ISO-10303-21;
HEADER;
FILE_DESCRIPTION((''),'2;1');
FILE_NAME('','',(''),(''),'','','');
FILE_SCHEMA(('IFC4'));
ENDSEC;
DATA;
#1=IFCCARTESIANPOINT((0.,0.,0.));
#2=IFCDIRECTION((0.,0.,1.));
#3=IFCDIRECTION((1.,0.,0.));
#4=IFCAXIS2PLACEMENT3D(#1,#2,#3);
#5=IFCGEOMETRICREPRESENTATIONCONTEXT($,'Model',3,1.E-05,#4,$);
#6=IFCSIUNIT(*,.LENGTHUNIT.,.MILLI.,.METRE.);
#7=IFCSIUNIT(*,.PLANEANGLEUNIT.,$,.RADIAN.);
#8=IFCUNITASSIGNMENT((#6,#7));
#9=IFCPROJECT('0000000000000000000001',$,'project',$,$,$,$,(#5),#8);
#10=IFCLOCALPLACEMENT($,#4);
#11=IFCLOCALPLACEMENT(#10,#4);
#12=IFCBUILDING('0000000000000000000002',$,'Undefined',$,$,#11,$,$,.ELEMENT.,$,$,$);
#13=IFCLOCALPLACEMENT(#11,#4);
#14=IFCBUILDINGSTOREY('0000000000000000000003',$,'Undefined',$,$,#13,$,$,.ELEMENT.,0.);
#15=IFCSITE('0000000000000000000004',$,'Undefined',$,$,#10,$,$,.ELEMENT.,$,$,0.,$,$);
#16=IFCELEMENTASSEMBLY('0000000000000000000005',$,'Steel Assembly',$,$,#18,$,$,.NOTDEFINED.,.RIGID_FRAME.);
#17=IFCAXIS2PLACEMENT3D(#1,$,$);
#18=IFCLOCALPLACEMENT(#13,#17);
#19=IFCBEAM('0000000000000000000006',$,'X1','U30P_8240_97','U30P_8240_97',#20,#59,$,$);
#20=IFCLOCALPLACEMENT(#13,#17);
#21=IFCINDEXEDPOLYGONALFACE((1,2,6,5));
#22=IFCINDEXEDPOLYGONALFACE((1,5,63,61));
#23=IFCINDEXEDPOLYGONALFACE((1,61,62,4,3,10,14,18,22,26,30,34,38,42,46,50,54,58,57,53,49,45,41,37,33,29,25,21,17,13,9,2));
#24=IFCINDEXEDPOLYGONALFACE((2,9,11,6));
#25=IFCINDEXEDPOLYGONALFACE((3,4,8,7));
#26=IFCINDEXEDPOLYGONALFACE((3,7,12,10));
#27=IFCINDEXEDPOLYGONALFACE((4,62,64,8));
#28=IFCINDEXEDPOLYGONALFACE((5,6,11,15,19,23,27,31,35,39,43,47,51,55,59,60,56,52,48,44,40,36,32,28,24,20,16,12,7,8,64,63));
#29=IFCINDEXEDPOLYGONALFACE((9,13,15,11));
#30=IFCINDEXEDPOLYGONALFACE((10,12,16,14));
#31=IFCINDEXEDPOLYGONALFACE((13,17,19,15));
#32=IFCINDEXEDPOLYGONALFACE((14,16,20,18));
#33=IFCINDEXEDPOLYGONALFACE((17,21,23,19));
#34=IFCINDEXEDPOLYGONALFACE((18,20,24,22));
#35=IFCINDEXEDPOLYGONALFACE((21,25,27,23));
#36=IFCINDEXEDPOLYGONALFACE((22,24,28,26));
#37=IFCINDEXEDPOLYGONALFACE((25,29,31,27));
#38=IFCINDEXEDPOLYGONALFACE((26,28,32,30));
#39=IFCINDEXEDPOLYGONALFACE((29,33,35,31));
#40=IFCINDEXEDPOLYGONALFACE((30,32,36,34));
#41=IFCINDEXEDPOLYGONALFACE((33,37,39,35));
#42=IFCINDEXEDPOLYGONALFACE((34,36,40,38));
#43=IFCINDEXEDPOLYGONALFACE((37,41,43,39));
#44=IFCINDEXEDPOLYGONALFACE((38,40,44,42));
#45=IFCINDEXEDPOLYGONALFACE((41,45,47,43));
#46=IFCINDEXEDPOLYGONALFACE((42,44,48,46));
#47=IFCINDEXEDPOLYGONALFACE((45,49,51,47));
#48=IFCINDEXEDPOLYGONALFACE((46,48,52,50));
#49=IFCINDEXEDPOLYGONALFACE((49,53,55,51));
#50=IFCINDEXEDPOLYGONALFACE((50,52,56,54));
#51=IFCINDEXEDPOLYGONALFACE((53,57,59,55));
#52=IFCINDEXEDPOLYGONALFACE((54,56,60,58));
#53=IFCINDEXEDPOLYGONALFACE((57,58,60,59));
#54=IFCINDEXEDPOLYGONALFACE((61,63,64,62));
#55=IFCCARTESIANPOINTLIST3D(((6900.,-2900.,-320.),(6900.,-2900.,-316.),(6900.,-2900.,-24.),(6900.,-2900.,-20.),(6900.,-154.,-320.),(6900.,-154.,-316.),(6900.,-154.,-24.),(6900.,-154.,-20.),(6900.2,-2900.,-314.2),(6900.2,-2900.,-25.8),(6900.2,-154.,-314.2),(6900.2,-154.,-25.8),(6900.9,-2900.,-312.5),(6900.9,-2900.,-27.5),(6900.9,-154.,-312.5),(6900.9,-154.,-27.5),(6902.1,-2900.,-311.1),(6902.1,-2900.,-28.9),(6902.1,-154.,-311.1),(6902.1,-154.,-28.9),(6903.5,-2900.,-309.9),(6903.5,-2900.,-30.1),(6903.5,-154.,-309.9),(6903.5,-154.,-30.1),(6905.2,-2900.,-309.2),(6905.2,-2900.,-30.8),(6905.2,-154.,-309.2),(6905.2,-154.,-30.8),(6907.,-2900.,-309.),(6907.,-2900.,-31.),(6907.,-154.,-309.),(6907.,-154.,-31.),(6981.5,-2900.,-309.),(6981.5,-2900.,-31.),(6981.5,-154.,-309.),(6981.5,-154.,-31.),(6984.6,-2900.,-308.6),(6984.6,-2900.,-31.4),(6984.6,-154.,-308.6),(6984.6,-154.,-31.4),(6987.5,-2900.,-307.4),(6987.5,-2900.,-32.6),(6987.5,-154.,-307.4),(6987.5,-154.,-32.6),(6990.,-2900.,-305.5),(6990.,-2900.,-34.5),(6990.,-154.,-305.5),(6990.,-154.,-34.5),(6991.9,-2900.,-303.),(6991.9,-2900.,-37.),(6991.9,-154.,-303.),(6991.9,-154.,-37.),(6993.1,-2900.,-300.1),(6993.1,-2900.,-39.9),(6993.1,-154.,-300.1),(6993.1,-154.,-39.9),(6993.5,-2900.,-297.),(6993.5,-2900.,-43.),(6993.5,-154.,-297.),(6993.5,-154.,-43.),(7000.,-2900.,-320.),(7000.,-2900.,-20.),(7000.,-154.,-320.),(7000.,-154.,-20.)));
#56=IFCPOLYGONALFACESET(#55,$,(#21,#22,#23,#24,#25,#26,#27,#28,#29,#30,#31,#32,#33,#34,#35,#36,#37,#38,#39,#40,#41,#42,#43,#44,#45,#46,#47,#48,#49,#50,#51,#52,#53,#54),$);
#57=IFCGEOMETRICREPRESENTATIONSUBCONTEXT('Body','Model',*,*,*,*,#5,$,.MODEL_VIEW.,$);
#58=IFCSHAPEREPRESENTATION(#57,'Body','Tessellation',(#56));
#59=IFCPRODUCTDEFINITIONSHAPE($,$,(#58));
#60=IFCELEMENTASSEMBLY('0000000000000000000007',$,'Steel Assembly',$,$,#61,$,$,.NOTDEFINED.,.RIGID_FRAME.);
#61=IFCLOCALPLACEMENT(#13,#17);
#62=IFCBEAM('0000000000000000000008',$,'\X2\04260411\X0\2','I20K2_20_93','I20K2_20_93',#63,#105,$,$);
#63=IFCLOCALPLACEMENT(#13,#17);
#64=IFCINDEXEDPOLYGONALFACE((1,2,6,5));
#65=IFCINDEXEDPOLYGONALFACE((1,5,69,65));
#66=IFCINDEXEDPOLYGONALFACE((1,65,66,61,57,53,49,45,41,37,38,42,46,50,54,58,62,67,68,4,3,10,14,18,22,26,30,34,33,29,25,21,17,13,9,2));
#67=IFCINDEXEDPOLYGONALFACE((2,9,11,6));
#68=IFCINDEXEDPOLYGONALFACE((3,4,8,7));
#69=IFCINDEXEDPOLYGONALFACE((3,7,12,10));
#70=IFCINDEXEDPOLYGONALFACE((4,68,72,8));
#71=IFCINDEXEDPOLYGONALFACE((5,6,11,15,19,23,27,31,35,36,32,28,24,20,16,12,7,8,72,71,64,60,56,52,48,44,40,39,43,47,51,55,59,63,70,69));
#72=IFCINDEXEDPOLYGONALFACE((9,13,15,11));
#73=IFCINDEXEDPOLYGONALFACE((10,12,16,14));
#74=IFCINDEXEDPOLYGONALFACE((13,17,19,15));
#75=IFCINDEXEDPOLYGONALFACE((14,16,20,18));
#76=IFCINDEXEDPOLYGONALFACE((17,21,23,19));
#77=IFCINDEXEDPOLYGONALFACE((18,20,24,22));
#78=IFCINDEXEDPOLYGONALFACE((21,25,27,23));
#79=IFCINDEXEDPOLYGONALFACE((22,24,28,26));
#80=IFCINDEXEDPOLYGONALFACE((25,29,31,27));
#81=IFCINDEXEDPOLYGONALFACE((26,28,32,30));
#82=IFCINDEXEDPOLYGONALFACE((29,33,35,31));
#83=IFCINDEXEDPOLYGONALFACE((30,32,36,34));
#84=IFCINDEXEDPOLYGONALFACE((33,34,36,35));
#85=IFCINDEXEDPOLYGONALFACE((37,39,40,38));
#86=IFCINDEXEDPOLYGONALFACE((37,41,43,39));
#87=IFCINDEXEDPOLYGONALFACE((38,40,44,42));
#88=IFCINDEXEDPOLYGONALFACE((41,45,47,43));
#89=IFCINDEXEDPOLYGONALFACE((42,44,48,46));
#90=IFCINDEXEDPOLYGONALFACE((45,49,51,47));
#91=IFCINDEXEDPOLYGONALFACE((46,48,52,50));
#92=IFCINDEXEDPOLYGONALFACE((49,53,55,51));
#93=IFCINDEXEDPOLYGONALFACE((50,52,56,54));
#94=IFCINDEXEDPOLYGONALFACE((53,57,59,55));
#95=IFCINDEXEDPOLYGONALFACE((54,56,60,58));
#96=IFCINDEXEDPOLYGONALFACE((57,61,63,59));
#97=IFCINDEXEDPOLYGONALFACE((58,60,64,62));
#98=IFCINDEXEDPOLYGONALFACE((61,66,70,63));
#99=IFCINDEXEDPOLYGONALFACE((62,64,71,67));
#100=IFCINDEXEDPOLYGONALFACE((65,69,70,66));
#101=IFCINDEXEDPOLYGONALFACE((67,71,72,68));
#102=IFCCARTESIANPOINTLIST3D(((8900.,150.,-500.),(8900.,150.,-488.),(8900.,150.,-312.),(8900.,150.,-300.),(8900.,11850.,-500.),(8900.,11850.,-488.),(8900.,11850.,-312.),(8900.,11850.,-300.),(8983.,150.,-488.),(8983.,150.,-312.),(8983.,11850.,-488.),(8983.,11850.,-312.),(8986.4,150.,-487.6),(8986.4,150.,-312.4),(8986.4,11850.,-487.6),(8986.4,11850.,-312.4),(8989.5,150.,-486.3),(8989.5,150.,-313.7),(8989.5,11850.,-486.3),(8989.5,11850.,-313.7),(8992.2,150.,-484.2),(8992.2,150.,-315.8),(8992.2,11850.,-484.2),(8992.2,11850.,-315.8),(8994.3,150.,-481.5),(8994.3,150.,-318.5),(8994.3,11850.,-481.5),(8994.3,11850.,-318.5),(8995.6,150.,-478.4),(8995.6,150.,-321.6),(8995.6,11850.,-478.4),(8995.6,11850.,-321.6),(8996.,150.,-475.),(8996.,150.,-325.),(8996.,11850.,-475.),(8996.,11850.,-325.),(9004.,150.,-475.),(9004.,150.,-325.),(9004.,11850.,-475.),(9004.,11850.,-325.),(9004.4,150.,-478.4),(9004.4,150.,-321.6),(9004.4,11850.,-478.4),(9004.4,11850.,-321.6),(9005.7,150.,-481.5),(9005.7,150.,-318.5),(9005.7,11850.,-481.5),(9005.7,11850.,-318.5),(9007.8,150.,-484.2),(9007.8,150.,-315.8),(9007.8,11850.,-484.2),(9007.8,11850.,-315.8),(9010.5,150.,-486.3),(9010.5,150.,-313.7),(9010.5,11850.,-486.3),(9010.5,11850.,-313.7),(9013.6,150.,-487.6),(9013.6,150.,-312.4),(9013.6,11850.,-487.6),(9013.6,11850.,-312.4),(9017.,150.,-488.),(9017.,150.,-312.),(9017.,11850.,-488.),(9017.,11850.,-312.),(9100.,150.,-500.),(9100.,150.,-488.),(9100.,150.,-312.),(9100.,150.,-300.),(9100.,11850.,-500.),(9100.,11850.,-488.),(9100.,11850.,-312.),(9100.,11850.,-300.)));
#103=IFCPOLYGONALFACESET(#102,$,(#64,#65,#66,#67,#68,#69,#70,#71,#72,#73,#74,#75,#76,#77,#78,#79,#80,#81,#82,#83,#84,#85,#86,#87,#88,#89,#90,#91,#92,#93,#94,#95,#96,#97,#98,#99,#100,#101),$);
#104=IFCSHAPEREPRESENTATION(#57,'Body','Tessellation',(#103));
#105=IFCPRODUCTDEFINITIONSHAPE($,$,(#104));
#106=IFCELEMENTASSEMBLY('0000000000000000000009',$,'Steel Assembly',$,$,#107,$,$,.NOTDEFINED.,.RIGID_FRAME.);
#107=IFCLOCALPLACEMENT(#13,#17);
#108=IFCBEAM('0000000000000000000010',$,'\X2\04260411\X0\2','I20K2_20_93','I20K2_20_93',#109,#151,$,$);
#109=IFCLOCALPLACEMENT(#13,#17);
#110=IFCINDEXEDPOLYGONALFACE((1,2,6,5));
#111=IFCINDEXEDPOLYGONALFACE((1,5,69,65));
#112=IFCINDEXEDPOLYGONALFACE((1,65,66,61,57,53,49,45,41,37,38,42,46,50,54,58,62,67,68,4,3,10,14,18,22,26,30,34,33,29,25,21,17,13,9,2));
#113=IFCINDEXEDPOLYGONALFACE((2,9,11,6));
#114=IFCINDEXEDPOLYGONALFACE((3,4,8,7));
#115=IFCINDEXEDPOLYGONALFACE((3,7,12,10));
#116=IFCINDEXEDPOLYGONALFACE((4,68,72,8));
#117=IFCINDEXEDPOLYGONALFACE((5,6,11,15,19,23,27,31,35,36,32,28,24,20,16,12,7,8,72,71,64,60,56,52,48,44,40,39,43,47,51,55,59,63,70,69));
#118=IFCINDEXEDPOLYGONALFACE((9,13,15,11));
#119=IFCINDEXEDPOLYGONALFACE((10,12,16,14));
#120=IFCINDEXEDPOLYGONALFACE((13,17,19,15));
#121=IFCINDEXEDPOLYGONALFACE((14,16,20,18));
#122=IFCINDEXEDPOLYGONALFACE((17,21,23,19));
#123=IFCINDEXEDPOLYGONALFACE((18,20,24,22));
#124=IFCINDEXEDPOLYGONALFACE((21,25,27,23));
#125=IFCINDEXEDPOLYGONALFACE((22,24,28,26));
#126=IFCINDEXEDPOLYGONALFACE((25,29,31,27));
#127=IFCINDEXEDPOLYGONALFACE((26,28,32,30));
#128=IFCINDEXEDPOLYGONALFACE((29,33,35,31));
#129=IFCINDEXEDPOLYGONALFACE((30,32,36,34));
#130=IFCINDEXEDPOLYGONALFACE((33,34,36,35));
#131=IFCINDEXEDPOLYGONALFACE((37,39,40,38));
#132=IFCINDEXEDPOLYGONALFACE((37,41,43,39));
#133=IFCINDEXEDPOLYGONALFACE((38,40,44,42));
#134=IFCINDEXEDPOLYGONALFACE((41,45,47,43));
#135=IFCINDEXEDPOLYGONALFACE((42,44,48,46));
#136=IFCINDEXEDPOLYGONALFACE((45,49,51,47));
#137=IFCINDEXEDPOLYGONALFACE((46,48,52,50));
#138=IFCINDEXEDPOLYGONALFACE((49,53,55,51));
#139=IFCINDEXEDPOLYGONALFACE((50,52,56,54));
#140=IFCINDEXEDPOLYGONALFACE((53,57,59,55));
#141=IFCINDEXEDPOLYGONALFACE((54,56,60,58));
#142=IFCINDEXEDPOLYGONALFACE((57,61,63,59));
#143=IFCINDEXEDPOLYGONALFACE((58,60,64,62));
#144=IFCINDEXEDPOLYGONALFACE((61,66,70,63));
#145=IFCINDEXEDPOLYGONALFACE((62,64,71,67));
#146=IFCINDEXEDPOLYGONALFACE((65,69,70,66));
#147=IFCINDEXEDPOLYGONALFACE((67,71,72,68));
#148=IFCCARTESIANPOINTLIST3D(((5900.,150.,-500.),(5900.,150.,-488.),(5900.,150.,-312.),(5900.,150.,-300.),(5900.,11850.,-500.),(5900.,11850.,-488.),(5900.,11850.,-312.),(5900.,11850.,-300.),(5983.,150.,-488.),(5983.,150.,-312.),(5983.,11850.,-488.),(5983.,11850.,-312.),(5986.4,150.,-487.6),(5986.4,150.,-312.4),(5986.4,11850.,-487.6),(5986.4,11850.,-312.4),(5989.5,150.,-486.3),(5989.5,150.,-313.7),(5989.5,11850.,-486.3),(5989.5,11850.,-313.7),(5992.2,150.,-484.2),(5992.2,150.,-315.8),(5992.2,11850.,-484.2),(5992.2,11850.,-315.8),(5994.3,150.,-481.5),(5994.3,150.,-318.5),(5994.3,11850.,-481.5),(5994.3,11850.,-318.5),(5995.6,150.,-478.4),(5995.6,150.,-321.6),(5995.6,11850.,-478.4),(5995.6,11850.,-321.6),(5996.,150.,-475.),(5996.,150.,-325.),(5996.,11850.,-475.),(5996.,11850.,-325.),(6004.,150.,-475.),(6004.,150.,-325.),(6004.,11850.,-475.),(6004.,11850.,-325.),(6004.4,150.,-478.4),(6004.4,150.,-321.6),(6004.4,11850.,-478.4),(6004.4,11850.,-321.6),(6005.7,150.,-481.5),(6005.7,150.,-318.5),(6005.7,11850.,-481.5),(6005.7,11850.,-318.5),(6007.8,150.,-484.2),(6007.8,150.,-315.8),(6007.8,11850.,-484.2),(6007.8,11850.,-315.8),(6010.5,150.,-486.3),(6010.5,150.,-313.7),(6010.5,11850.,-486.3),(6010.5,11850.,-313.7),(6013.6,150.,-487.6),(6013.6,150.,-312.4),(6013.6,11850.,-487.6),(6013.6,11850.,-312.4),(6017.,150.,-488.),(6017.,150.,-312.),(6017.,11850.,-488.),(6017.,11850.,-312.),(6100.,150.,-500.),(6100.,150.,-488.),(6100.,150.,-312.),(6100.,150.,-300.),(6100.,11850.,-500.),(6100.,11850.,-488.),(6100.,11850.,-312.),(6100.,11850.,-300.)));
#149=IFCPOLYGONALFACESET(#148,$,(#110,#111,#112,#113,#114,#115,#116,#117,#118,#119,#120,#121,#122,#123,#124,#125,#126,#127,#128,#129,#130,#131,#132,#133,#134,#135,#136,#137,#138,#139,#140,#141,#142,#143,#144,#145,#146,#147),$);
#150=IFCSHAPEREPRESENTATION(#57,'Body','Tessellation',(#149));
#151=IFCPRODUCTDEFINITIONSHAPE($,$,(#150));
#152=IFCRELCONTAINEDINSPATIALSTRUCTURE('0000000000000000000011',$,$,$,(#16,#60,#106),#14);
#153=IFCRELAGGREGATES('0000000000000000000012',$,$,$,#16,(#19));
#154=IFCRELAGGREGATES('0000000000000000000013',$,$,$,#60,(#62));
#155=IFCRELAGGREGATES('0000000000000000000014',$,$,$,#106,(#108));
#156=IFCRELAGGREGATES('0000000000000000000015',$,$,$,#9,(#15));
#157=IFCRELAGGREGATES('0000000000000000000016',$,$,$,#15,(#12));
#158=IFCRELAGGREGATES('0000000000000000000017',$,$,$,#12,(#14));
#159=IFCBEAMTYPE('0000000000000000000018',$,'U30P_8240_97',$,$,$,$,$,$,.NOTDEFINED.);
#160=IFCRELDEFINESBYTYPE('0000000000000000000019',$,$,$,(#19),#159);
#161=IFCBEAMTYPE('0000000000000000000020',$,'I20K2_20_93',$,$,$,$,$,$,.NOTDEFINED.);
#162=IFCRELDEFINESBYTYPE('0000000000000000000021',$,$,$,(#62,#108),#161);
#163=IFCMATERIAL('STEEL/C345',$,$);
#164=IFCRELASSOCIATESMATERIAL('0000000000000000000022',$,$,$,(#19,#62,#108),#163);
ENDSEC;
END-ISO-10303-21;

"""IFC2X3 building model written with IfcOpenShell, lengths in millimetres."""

from ifc_helpers import new_model, si_unit, frame, origin_with_axes, origin_2d_with_axis, place, context, subcontext, project, spatial, i_section, u_section, extrude, material, type_object, element, aggregate, save


model = new_model("IFC2X3")

# Units and contexts
model_context = context("Model", 3, precision=1e-05, world=origin_with_axes())
body_context = subcontext(model_context, "Body", "Model", "MODEL_VIEW")
ifc_project = project(units=[si_unit("LENGTHUNIT", "METRE", prefix="MILLI"), si_unit("PLANEANGLEUNIT", "RADIAN")], contexts=[model_context])

# Site, building, storey
site_placement = place(None, origin_with_axes())
site = spatial("IfcSite", under=ifc_project, at=site_placement, Name="Undefined", CompositionType="ELEMENT", RefElevation=0.0)
building_placement = place(site_placement, origin_with_axes())
building = spatial("IfcBuilding", under=site, at=building_placement, Name="Undefined", CompositionType="ELEMENT")
storey_placement = place(building_placement, origin_with_axes())
storey = spatial("IfcBuildingStorey", under=building, at=storey_placement, Name="Undefined", CompositionType="ELEMENT", Elevation=0.0)

# Shared definitions
ifc_material_1 = material(Name="STEEL/C345")

# Element assemblies, beams
beam_type_1 = type_object("IfcBeamType", Name="U30P_8240_97", PredefinedType="NOTDEFINED")
assembly_1_placement = place(storey_placement, origin_with_axes())
assembly_1 = element("IfcElementAssembly", 1, at=assembly_1_placement, inside=storey, Name="Steel Assembly", AssemblyPlace="NOTDEFINED", PredefinedType="RIGID_FRAME")
beam_1_placement = place(assembly_1_placement, frame((6950.0, -154.0, -170.0), z_axis=(0.0, 0.0, 1.0), x_axis=(0.0, -1.0, 0.0)))
beam_1 = element("IfcBeam", 2, at=beam_1_placement, type_object=beam_type_1, material=ifc_material_1, Name="X1", Description="U30P_8240_97", ObjectType="U30P_8240_97", context=body_context, shape_type="SweptSolid", body=[
    extrude(u_section(Depth=300.0, FlangeWidth=100.0, WebThickness=6.5, FlangeThickness=11.0, FilletRadius=12.0, EdgeRadius=7.0, at=origin_2d_with_axis()), frame((2746.0, 0.0, 0.0), z_axis=(-1.0, 0.0, 0.0), x_axis=(0.0, -1.0, 0.0)), (0.0, 0.0, 1.0), 2746.0),
])
aggregate(assembly_1, [beam_1])
assembly_2_placement = place(storey_placement, origin_with_axes())
assembly_2 = element("IfcElementAssembly", 3, at=assembly_2_placement, inside=storey, Name="Steel Assembly", AssemblyPlace="NOTDEFINED", PredefinedType="RIGID_FRAME")
beam_type_2 = type_object("IfcBeamType", Name="I20K2_20_93", PredefinedType="NOTDEFINED")
beam_2_placement = place(assembly_2_placement, frame((9000.0, 150.0, -400.0), z_axis=(0.0, 0.0, 1.0), x_axis=(0.0, 1.0, 0.0)))
beam_2 = element("IfcBeam", 4, at=beam_2_placement, type_object=beam_type_2, material=ifc_material_1, Name="ЦБ2", Description="I20K2_20_93", ObjectType="I20K2_20_93", context=body_context, shape_type="SweptSolid", body=[
    extrude(i_section(OverallWidth=200.0, OverallDepth=200.0, WebThickness=8.0, FlangeThickness=12.0, FilletRadius=13.0, at=origin_2d_with_axis()), frame((11700.0, 0.0, 0.0), z_axis=(-1.0, 0.0, 0.0), x_axis=(0.0, -1.0, 0.0)), (0.0, 0.0, 1.0), 11700.0),
])
aggregate(assembly_2, [beam_2])
assembly_3_placement = place(storey_placement, origin_with_axes())
assembly_3 = element("IfcElementAssembly", 5, at=assembly_3_placement, inside=storey, Name="Steel Assembly", AssemblyPlace="NOTDEFINED", PredefinedType="RIGID_FRAME")
beam_3_placement = place(assembly_3_placement, frame((6000.0, 150.0, -400.0), z_axis=(0.0, 0.0, 1.0), x_axis=(0.0, 1.0, 0.0)))
beam_3 = element("IfcBeam", 6, at=beam_3_placement, type_object=beam_type_2, material=ifc_material_1, Name="ЦБ2", Description="I20K2_20_93", ObjectType="I20K2_20_93", context=body_context, shape_type="SweptSolid", body=[
    extrude(i_section(OverallWidth=200.0, OverallDepth=200.0, WebThickness=8.0, FlangeThickness=12.0, FilletRadius=13.0, at=origin_2d_with_axis()), frame((11700.0, 0.0, 0.0), z_axis=(-1.0, 0.0, 0.0), x_axis=(0.0, -1.0, 0.0)), (0.0, 0.0, 1.0), 11700.0),
])
aggregate(assembly_3, [beam_3])

save(model, "model.ifc")
